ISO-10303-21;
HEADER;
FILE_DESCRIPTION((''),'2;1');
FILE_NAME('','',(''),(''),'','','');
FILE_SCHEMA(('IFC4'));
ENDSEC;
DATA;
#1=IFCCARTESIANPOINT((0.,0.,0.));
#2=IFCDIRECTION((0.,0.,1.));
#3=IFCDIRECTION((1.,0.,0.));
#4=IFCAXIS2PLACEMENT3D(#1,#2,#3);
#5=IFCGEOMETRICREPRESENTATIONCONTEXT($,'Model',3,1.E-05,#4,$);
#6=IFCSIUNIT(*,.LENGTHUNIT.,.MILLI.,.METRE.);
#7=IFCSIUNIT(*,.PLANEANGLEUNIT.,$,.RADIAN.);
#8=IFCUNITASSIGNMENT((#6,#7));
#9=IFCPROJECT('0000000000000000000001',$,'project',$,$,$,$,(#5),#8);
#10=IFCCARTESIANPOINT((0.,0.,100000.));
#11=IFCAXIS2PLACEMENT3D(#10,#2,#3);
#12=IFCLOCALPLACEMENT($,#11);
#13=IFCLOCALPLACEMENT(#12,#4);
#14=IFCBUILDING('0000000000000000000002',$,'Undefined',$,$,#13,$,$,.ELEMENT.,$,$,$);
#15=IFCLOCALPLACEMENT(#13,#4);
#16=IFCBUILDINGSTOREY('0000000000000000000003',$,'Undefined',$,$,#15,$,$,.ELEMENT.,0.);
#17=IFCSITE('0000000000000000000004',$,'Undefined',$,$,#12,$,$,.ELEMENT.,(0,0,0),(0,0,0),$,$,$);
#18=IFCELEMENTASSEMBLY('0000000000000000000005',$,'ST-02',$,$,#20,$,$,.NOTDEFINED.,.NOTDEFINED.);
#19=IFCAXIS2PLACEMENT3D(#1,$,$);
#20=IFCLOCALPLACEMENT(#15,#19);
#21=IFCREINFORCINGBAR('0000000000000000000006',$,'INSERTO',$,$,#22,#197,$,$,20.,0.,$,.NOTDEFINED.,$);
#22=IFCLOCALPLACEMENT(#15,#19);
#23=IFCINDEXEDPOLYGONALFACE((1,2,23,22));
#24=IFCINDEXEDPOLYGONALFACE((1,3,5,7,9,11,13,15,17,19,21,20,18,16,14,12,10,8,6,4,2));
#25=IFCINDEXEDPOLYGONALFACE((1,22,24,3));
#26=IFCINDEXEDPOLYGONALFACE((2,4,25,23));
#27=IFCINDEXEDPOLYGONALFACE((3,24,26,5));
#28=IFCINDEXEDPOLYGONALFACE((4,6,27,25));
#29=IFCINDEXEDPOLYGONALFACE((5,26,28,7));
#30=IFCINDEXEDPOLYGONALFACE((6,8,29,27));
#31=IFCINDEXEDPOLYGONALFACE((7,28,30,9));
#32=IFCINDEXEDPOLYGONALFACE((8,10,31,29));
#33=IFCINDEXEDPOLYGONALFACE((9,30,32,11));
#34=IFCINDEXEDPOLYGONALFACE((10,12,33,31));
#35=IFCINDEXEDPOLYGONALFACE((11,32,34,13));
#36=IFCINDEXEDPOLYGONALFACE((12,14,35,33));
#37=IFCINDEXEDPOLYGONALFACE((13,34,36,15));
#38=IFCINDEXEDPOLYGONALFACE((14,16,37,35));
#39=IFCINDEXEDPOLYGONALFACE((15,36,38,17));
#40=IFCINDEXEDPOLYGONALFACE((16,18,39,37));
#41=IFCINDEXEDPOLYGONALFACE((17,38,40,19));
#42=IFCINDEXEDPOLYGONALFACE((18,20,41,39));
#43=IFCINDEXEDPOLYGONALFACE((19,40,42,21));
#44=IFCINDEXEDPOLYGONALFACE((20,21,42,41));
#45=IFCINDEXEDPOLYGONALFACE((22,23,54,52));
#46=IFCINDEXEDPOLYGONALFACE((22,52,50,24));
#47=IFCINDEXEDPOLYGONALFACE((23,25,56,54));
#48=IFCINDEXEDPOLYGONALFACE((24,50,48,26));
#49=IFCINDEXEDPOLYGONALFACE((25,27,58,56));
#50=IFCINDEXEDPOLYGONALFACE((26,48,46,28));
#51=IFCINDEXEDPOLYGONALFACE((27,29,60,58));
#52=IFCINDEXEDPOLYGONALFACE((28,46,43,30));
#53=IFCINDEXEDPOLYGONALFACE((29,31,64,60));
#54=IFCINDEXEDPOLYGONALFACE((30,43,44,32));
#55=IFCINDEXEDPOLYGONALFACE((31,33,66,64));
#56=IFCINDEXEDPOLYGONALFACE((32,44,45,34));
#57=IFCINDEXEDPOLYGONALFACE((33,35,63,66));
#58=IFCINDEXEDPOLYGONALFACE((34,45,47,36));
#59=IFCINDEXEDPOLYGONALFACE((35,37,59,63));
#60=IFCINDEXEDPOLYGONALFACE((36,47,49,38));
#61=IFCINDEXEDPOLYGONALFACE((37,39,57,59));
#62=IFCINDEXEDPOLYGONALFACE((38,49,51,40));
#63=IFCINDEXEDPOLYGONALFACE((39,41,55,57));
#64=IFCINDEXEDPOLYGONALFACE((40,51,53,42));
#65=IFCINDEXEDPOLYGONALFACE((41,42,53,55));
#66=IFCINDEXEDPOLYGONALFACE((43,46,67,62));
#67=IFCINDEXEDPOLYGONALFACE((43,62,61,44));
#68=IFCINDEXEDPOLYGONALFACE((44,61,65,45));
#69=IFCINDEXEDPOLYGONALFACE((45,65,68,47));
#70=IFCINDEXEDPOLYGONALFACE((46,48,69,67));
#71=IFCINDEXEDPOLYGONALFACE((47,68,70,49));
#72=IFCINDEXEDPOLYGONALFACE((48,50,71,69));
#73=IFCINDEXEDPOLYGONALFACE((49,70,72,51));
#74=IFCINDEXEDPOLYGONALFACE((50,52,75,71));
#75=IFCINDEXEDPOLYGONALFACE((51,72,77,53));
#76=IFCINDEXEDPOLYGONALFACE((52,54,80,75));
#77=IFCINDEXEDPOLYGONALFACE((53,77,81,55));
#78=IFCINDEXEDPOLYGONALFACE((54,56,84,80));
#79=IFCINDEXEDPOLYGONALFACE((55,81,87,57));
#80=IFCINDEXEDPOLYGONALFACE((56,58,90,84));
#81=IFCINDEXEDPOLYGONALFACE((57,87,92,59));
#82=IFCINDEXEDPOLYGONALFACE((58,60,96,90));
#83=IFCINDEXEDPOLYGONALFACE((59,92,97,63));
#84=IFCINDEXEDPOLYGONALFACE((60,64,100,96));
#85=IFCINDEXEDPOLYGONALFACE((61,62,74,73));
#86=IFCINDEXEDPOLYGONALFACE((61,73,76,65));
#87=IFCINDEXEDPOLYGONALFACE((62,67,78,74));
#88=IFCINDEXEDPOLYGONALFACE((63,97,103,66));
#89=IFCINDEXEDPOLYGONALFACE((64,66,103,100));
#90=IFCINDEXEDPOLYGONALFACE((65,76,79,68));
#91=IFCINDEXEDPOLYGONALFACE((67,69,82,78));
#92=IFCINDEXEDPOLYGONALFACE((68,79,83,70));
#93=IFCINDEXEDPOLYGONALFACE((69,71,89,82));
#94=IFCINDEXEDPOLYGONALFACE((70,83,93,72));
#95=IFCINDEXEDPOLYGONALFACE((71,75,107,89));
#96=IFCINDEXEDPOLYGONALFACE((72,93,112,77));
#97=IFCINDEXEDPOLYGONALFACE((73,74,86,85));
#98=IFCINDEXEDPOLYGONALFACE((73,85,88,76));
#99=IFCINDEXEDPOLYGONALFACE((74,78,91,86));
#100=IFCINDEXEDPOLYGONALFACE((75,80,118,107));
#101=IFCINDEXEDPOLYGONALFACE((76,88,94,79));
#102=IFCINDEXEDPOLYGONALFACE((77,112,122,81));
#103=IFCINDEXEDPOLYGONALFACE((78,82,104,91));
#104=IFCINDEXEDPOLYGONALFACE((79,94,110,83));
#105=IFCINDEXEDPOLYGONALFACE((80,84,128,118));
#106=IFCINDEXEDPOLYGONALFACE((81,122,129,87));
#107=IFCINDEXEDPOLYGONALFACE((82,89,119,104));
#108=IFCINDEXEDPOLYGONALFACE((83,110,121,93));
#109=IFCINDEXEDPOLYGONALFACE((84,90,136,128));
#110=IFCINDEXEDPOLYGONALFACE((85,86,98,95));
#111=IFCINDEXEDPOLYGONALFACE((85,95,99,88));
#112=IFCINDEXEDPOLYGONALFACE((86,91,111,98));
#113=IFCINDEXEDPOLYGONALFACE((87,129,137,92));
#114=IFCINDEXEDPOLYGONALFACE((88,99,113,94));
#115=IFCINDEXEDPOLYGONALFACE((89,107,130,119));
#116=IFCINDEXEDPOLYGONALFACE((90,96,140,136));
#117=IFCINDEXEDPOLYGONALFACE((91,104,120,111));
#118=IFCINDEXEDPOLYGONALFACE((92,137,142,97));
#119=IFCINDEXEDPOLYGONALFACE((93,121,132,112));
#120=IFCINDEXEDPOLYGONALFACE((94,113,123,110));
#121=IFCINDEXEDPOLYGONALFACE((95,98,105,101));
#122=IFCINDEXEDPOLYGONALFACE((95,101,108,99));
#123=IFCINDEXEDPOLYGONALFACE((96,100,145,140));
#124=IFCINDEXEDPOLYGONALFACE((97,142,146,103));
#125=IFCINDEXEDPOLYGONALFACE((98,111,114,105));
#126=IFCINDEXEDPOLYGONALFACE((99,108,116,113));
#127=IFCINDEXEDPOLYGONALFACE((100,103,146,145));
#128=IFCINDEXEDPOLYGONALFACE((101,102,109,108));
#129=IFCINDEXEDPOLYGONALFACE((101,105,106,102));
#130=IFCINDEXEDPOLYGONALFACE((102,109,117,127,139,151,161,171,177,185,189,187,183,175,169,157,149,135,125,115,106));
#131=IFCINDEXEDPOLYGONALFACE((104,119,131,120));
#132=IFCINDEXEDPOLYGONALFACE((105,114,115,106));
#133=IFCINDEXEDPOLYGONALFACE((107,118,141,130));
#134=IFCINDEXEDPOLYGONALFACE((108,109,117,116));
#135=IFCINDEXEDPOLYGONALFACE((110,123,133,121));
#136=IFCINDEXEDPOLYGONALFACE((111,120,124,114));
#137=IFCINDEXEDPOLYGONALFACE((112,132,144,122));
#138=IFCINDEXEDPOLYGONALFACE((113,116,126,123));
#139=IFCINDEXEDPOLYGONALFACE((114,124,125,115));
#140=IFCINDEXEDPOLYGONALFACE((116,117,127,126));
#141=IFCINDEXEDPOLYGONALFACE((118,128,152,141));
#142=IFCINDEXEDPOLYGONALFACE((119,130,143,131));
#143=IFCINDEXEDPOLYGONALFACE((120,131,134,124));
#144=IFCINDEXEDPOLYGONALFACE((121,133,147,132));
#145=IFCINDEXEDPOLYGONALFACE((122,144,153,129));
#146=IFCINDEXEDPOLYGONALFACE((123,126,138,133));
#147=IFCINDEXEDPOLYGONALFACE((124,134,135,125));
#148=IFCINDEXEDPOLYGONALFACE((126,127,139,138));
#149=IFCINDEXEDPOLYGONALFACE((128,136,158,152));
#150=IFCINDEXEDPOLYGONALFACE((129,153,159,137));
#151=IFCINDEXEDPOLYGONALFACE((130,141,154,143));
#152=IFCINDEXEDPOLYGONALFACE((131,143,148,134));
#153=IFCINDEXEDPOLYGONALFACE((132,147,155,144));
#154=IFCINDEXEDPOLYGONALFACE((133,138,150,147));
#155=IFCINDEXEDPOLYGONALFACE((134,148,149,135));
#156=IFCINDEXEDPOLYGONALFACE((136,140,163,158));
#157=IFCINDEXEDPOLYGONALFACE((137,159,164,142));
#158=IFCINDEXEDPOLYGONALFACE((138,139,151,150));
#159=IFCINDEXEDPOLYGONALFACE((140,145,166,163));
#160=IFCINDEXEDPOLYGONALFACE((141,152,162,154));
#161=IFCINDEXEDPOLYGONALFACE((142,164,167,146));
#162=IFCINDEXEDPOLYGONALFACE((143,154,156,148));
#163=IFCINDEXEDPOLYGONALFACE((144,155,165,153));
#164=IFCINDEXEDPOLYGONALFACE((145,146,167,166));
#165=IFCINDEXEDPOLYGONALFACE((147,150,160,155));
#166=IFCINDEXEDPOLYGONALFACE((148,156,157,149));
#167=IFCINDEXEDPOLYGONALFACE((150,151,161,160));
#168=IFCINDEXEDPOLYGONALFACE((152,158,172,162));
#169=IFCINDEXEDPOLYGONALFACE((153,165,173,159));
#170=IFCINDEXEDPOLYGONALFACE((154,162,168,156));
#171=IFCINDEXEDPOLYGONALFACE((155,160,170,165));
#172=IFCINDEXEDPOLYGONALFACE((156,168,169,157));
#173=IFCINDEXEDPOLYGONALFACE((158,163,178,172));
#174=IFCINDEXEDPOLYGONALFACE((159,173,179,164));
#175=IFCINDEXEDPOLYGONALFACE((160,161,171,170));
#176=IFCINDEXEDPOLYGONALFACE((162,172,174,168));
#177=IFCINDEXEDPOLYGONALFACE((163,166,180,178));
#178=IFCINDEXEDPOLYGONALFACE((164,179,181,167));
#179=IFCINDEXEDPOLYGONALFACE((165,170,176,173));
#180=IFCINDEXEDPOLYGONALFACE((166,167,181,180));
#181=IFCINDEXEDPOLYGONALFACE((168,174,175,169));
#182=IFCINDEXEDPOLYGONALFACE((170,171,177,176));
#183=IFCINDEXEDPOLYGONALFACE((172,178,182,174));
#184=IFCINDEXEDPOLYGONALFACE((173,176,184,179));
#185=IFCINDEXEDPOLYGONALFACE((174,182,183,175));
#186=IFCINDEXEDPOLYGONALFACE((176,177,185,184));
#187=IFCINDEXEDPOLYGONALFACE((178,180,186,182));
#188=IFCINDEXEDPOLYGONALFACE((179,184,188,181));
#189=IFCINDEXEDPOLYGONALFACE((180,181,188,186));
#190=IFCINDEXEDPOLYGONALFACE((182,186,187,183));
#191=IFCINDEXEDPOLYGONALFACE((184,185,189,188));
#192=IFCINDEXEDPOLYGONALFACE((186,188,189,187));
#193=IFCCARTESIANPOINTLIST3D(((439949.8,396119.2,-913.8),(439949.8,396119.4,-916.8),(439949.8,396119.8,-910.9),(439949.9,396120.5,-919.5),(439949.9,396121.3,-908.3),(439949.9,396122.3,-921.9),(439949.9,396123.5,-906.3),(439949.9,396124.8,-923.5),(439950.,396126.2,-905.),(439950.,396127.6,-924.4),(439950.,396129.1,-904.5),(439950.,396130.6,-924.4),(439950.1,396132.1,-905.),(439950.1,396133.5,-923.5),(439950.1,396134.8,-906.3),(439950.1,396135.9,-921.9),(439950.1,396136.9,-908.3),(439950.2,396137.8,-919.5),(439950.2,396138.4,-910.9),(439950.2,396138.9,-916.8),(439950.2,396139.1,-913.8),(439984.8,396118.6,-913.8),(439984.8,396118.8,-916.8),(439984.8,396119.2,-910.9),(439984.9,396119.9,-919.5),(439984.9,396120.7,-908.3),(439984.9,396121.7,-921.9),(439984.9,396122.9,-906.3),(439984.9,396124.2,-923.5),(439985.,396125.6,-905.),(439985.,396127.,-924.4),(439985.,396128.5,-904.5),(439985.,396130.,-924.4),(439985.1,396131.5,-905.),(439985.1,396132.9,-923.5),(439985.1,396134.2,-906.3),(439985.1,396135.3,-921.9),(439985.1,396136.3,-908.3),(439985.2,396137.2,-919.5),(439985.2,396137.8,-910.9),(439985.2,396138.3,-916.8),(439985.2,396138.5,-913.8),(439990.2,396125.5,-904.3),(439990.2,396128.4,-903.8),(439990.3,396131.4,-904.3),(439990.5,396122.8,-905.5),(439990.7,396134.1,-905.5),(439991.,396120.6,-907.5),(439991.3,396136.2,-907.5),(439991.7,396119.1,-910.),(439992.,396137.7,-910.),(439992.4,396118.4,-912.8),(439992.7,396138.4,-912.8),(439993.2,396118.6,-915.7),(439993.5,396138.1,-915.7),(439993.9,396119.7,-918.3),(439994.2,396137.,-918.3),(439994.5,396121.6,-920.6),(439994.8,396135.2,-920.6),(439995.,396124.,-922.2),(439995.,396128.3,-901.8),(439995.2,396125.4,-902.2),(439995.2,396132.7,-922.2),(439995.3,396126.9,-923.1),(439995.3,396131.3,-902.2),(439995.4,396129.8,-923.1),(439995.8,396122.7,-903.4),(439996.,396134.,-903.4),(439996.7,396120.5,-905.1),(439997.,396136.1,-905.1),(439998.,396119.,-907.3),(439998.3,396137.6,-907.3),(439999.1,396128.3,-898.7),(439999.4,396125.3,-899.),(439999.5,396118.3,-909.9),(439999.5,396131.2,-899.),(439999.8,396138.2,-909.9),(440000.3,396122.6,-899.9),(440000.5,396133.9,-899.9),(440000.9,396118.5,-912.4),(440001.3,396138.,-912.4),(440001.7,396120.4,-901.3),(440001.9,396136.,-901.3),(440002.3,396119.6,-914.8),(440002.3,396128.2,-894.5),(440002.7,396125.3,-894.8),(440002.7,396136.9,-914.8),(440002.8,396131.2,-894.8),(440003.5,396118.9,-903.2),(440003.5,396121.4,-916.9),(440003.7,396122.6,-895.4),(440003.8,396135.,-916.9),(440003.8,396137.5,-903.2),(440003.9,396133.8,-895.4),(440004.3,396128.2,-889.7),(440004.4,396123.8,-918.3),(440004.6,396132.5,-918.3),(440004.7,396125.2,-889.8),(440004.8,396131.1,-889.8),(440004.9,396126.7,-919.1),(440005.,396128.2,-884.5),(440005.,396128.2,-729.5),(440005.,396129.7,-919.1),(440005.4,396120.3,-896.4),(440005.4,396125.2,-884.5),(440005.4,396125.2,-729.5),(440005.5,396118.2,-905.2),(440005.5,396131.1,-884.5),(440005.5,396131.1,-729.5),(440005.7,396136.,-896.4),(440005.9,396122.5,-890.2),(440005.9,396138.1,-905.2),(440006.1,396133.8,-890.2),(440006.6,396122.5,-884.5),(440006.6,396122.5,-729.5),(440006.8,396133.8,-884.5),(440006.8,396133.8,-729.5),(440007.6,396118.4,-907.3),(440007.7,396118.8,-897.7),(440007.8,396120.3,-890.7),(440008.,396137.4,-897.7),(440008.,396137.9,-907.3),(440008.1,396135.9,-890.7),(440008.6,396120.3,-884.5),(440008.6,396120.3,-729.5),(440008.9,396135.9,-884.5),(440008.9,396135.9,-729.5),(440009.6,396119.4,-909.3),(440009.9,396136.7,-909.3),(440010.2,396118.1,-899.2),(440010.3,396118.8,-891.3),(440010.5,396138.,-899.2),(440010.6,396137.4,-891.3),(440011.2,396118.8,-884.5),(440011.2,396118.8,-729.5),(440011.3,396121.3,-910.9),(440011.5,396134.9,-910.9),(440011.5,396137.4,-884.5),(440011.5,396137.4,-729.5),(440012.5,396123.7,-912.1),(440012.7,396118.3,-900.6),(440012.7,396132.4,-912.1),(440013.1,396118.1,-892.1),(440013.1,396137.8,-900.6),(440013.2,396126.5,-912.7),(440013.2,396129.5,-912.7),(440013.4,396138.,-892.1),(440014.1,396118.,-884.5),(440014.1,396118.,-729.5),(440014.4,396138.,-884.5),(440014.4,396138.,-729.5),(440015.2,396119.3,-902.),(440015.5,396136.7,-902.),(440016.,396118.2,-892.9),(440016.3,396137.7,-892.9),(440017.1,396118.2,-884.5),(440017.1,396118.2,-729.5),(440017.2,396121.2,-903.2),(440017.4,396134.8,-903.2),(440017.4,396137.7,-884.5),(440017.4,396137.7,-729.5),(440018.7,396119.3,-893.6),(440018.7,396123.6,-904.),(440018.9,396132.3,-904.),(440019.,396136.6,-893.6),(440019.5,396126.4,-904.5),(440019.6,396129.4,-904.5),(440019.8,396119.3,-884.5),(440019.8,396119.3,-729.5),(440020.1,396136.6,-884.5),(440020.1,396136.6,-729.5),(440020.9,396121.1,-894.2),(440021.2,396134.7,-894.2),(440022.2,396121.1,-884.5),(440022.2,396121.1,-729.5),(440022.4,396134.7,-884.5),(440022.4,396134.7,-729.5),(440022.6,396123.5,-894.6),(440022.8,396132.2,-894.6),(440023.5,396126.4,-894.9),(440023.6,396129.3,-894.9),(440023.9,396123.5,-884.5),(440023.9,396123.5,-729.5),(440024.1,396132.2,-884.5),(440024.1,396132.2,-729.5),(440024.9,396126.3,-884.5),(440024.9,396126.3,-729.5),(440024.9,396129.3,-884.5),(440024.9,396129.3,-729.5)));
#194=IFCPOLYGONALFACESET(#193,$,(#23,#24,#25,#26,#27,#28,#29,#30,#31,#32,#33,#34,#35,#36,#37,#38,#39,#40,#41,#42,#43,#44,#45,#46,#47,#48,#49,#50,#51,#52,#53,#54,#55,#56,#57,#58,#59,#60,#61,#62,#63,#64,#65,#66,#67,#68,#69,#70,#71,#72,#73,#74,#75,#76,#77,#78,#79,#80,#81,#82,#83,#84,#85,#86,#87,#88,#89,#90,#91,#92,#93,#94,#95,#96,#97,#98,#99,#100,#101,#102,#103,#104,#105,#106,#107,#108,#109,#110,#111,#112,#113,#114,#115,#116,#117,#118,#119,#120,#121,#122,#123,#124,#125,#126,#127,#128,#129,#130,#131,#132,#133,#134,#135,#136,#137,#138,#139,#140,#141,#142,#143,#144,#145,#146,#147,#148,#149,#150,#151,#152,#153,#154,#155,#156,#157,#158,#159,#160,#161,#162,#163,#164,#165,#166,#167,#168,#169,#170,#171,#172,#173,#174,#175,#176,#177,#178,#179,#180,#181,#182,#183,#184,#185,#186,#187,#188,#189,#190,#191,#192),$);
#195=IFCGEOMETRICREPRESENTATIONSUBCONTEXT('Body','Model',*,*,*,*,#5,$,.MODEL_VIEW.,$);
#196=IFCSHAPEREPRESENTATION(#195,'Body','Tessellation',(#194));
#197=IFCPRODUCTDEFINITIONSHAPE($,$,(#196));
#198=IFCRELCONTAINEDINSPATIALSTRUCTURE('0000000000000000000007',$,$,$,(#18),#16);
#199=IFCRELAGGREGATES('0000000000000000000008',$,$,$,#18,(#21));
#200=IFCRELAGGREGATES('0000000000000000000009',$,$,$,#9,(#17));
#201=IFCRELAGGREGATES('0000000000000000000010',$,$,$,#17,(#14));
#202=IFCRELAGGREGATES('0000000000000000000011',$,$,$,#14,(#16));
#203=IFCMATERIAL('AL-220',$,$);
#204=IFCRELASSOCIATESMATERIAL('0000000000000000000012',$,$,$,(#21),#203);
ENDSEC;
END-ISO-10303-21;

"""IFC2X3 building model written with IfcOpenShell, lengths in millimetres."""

from ifc_helpers import new_model, entity, si_unit, frame, origin_with_axes, place, context, subcontext, project, spatial, source, transform, mapped, material, element, aggregate, save


model = new_model("IFC2X3")

# Units and contexts
model_context = context("Model", 3, precision=1e-05, world=origin_with_axes())
body_context = subcontext(model_context, "Body", "Model", "MODEL_VIEW")
ifc_project = project(units=[si_unit("LENGTHUNIT", "METRE", prefix="MILLI"), si_unit("PLANEANGLEUNIT", "RADIAN")], contexts=[model_context])

# Site, building, storey
site_placement = place(None, frame((0.0, 0.0, 100000.0), z_axis=(0.0, 0.0, 1.0), x_axis=(1.0, 0.0, 0.0)))
site = spatial("IfcSite", under=ifc_project, at=site_placement, Name="Undefined", CompositionType="ELEMENT", RefLatitude=(0, 0, 0), RefLongitude=(0, 0, 0))
building_placement = place(site_placement, origin_with_axes())
building = spatial("IfcBuilding", under=site, at=building_placement, Name="Undefined", CompositionType="ELEMENT")
storey_placement = place(building_placement, origin_with_axes())
storey = spatial("IfcBuildingStorey", under=building, at=storey_placement, Name="Undefined", CompositionType="ELEMENT", Elevation=0.0)

# Element assembly
assembly_1_placement = place(storey_placement, origin_with_axes())
assembly_1 = element("IfcElementAssembly", 1, at=assembly_1_placement, inside=storey, Name="ST-02", AssemblyPlace="NOTDEFINED", PredefinedType="NOTDEFINED")

# Reinforcing bar
ifc_material_1 = material(Name="AL-220")
shared_shape_1 = source(origin_with_axes(), body_context, "Body", "AdvancedSweptSolid", [
    entity("IfcSweptDiskSolid", entity("IfcCompositeCurve", [entity("IfcCompositeCurveSegment", "CONTINUOUS", True, entity("IfcTrimmedCurve", entity("IfcLine", entity("IfcCartesianPoint", [0.0, 0.0, 0.0]), entity("IfcVector", entity("IfcDirection", [1.0, 0.0, 0.0]), 1.0)), [entity("IfcParameterValue", 0.0)], [entity("IfcParameterValue", 155.0)], True, "PARAMETER")), entity("IfcCompositeCurveSegment", "CONTINUOUS", True, entity("IfcTrimmedCurve", entity("IfcCircle", entity("IfcAxis2Placement3D", entity("IfcCartesianPoint", [155.0, 0.0, 30.0]), entity("IfcDirection", [0.0, -1.0, 0.0]), entity("IfcDirection", [0.0, 0.0, -1.0])), 30.0), [entity("IfcParameterValue", 0.0)], [entity("IfcParameterValue", 1.570796)], True, "PARAMETER")), entity("IfcCompositeCurveSegment", "DISCONTINUOUS", True, entity("IfcTrimmedCurve", entity("IfcLine", entity("IfcCartesianPoint", [185.0, 0.0, 30.0]), entity("IfcVector", entity("IfcDirection", [0.0, 0.0, 1.0]), 1.0)), [entity("IfcParameterValue", 0.0)], [entity("IfcParameterValue", 35.0)], True, "PARAMETER"))], False), 10.0, None, 0.0, 191.6),
])
reinforcing_bar_1_placement = place(assembly_1_placement, frame((440015.0, 396128.0, -729.5), z_axis=(-0.999848, 0.017452, 0.0), x_axis=(0.0, 0.0, -1.0)))
reinforcing_bar_1 = element("IfcReinforcingBar", 2, at=reinforcing_bar_1_placement, material=ifc_material_1, Name="INSERTO", BarRole="NOTDEFINED", CrossSectionArea=0.0, NominalDiameter=20.0, context=body_context, shape_type="MappedRepresentation", body=[
    mapped(shared_shape_1, transform((0.0, 0.0, 0.0))),
])
aggregate(assembly_1, [reinforcing_bar_1])

save(model, "model.ifc")
